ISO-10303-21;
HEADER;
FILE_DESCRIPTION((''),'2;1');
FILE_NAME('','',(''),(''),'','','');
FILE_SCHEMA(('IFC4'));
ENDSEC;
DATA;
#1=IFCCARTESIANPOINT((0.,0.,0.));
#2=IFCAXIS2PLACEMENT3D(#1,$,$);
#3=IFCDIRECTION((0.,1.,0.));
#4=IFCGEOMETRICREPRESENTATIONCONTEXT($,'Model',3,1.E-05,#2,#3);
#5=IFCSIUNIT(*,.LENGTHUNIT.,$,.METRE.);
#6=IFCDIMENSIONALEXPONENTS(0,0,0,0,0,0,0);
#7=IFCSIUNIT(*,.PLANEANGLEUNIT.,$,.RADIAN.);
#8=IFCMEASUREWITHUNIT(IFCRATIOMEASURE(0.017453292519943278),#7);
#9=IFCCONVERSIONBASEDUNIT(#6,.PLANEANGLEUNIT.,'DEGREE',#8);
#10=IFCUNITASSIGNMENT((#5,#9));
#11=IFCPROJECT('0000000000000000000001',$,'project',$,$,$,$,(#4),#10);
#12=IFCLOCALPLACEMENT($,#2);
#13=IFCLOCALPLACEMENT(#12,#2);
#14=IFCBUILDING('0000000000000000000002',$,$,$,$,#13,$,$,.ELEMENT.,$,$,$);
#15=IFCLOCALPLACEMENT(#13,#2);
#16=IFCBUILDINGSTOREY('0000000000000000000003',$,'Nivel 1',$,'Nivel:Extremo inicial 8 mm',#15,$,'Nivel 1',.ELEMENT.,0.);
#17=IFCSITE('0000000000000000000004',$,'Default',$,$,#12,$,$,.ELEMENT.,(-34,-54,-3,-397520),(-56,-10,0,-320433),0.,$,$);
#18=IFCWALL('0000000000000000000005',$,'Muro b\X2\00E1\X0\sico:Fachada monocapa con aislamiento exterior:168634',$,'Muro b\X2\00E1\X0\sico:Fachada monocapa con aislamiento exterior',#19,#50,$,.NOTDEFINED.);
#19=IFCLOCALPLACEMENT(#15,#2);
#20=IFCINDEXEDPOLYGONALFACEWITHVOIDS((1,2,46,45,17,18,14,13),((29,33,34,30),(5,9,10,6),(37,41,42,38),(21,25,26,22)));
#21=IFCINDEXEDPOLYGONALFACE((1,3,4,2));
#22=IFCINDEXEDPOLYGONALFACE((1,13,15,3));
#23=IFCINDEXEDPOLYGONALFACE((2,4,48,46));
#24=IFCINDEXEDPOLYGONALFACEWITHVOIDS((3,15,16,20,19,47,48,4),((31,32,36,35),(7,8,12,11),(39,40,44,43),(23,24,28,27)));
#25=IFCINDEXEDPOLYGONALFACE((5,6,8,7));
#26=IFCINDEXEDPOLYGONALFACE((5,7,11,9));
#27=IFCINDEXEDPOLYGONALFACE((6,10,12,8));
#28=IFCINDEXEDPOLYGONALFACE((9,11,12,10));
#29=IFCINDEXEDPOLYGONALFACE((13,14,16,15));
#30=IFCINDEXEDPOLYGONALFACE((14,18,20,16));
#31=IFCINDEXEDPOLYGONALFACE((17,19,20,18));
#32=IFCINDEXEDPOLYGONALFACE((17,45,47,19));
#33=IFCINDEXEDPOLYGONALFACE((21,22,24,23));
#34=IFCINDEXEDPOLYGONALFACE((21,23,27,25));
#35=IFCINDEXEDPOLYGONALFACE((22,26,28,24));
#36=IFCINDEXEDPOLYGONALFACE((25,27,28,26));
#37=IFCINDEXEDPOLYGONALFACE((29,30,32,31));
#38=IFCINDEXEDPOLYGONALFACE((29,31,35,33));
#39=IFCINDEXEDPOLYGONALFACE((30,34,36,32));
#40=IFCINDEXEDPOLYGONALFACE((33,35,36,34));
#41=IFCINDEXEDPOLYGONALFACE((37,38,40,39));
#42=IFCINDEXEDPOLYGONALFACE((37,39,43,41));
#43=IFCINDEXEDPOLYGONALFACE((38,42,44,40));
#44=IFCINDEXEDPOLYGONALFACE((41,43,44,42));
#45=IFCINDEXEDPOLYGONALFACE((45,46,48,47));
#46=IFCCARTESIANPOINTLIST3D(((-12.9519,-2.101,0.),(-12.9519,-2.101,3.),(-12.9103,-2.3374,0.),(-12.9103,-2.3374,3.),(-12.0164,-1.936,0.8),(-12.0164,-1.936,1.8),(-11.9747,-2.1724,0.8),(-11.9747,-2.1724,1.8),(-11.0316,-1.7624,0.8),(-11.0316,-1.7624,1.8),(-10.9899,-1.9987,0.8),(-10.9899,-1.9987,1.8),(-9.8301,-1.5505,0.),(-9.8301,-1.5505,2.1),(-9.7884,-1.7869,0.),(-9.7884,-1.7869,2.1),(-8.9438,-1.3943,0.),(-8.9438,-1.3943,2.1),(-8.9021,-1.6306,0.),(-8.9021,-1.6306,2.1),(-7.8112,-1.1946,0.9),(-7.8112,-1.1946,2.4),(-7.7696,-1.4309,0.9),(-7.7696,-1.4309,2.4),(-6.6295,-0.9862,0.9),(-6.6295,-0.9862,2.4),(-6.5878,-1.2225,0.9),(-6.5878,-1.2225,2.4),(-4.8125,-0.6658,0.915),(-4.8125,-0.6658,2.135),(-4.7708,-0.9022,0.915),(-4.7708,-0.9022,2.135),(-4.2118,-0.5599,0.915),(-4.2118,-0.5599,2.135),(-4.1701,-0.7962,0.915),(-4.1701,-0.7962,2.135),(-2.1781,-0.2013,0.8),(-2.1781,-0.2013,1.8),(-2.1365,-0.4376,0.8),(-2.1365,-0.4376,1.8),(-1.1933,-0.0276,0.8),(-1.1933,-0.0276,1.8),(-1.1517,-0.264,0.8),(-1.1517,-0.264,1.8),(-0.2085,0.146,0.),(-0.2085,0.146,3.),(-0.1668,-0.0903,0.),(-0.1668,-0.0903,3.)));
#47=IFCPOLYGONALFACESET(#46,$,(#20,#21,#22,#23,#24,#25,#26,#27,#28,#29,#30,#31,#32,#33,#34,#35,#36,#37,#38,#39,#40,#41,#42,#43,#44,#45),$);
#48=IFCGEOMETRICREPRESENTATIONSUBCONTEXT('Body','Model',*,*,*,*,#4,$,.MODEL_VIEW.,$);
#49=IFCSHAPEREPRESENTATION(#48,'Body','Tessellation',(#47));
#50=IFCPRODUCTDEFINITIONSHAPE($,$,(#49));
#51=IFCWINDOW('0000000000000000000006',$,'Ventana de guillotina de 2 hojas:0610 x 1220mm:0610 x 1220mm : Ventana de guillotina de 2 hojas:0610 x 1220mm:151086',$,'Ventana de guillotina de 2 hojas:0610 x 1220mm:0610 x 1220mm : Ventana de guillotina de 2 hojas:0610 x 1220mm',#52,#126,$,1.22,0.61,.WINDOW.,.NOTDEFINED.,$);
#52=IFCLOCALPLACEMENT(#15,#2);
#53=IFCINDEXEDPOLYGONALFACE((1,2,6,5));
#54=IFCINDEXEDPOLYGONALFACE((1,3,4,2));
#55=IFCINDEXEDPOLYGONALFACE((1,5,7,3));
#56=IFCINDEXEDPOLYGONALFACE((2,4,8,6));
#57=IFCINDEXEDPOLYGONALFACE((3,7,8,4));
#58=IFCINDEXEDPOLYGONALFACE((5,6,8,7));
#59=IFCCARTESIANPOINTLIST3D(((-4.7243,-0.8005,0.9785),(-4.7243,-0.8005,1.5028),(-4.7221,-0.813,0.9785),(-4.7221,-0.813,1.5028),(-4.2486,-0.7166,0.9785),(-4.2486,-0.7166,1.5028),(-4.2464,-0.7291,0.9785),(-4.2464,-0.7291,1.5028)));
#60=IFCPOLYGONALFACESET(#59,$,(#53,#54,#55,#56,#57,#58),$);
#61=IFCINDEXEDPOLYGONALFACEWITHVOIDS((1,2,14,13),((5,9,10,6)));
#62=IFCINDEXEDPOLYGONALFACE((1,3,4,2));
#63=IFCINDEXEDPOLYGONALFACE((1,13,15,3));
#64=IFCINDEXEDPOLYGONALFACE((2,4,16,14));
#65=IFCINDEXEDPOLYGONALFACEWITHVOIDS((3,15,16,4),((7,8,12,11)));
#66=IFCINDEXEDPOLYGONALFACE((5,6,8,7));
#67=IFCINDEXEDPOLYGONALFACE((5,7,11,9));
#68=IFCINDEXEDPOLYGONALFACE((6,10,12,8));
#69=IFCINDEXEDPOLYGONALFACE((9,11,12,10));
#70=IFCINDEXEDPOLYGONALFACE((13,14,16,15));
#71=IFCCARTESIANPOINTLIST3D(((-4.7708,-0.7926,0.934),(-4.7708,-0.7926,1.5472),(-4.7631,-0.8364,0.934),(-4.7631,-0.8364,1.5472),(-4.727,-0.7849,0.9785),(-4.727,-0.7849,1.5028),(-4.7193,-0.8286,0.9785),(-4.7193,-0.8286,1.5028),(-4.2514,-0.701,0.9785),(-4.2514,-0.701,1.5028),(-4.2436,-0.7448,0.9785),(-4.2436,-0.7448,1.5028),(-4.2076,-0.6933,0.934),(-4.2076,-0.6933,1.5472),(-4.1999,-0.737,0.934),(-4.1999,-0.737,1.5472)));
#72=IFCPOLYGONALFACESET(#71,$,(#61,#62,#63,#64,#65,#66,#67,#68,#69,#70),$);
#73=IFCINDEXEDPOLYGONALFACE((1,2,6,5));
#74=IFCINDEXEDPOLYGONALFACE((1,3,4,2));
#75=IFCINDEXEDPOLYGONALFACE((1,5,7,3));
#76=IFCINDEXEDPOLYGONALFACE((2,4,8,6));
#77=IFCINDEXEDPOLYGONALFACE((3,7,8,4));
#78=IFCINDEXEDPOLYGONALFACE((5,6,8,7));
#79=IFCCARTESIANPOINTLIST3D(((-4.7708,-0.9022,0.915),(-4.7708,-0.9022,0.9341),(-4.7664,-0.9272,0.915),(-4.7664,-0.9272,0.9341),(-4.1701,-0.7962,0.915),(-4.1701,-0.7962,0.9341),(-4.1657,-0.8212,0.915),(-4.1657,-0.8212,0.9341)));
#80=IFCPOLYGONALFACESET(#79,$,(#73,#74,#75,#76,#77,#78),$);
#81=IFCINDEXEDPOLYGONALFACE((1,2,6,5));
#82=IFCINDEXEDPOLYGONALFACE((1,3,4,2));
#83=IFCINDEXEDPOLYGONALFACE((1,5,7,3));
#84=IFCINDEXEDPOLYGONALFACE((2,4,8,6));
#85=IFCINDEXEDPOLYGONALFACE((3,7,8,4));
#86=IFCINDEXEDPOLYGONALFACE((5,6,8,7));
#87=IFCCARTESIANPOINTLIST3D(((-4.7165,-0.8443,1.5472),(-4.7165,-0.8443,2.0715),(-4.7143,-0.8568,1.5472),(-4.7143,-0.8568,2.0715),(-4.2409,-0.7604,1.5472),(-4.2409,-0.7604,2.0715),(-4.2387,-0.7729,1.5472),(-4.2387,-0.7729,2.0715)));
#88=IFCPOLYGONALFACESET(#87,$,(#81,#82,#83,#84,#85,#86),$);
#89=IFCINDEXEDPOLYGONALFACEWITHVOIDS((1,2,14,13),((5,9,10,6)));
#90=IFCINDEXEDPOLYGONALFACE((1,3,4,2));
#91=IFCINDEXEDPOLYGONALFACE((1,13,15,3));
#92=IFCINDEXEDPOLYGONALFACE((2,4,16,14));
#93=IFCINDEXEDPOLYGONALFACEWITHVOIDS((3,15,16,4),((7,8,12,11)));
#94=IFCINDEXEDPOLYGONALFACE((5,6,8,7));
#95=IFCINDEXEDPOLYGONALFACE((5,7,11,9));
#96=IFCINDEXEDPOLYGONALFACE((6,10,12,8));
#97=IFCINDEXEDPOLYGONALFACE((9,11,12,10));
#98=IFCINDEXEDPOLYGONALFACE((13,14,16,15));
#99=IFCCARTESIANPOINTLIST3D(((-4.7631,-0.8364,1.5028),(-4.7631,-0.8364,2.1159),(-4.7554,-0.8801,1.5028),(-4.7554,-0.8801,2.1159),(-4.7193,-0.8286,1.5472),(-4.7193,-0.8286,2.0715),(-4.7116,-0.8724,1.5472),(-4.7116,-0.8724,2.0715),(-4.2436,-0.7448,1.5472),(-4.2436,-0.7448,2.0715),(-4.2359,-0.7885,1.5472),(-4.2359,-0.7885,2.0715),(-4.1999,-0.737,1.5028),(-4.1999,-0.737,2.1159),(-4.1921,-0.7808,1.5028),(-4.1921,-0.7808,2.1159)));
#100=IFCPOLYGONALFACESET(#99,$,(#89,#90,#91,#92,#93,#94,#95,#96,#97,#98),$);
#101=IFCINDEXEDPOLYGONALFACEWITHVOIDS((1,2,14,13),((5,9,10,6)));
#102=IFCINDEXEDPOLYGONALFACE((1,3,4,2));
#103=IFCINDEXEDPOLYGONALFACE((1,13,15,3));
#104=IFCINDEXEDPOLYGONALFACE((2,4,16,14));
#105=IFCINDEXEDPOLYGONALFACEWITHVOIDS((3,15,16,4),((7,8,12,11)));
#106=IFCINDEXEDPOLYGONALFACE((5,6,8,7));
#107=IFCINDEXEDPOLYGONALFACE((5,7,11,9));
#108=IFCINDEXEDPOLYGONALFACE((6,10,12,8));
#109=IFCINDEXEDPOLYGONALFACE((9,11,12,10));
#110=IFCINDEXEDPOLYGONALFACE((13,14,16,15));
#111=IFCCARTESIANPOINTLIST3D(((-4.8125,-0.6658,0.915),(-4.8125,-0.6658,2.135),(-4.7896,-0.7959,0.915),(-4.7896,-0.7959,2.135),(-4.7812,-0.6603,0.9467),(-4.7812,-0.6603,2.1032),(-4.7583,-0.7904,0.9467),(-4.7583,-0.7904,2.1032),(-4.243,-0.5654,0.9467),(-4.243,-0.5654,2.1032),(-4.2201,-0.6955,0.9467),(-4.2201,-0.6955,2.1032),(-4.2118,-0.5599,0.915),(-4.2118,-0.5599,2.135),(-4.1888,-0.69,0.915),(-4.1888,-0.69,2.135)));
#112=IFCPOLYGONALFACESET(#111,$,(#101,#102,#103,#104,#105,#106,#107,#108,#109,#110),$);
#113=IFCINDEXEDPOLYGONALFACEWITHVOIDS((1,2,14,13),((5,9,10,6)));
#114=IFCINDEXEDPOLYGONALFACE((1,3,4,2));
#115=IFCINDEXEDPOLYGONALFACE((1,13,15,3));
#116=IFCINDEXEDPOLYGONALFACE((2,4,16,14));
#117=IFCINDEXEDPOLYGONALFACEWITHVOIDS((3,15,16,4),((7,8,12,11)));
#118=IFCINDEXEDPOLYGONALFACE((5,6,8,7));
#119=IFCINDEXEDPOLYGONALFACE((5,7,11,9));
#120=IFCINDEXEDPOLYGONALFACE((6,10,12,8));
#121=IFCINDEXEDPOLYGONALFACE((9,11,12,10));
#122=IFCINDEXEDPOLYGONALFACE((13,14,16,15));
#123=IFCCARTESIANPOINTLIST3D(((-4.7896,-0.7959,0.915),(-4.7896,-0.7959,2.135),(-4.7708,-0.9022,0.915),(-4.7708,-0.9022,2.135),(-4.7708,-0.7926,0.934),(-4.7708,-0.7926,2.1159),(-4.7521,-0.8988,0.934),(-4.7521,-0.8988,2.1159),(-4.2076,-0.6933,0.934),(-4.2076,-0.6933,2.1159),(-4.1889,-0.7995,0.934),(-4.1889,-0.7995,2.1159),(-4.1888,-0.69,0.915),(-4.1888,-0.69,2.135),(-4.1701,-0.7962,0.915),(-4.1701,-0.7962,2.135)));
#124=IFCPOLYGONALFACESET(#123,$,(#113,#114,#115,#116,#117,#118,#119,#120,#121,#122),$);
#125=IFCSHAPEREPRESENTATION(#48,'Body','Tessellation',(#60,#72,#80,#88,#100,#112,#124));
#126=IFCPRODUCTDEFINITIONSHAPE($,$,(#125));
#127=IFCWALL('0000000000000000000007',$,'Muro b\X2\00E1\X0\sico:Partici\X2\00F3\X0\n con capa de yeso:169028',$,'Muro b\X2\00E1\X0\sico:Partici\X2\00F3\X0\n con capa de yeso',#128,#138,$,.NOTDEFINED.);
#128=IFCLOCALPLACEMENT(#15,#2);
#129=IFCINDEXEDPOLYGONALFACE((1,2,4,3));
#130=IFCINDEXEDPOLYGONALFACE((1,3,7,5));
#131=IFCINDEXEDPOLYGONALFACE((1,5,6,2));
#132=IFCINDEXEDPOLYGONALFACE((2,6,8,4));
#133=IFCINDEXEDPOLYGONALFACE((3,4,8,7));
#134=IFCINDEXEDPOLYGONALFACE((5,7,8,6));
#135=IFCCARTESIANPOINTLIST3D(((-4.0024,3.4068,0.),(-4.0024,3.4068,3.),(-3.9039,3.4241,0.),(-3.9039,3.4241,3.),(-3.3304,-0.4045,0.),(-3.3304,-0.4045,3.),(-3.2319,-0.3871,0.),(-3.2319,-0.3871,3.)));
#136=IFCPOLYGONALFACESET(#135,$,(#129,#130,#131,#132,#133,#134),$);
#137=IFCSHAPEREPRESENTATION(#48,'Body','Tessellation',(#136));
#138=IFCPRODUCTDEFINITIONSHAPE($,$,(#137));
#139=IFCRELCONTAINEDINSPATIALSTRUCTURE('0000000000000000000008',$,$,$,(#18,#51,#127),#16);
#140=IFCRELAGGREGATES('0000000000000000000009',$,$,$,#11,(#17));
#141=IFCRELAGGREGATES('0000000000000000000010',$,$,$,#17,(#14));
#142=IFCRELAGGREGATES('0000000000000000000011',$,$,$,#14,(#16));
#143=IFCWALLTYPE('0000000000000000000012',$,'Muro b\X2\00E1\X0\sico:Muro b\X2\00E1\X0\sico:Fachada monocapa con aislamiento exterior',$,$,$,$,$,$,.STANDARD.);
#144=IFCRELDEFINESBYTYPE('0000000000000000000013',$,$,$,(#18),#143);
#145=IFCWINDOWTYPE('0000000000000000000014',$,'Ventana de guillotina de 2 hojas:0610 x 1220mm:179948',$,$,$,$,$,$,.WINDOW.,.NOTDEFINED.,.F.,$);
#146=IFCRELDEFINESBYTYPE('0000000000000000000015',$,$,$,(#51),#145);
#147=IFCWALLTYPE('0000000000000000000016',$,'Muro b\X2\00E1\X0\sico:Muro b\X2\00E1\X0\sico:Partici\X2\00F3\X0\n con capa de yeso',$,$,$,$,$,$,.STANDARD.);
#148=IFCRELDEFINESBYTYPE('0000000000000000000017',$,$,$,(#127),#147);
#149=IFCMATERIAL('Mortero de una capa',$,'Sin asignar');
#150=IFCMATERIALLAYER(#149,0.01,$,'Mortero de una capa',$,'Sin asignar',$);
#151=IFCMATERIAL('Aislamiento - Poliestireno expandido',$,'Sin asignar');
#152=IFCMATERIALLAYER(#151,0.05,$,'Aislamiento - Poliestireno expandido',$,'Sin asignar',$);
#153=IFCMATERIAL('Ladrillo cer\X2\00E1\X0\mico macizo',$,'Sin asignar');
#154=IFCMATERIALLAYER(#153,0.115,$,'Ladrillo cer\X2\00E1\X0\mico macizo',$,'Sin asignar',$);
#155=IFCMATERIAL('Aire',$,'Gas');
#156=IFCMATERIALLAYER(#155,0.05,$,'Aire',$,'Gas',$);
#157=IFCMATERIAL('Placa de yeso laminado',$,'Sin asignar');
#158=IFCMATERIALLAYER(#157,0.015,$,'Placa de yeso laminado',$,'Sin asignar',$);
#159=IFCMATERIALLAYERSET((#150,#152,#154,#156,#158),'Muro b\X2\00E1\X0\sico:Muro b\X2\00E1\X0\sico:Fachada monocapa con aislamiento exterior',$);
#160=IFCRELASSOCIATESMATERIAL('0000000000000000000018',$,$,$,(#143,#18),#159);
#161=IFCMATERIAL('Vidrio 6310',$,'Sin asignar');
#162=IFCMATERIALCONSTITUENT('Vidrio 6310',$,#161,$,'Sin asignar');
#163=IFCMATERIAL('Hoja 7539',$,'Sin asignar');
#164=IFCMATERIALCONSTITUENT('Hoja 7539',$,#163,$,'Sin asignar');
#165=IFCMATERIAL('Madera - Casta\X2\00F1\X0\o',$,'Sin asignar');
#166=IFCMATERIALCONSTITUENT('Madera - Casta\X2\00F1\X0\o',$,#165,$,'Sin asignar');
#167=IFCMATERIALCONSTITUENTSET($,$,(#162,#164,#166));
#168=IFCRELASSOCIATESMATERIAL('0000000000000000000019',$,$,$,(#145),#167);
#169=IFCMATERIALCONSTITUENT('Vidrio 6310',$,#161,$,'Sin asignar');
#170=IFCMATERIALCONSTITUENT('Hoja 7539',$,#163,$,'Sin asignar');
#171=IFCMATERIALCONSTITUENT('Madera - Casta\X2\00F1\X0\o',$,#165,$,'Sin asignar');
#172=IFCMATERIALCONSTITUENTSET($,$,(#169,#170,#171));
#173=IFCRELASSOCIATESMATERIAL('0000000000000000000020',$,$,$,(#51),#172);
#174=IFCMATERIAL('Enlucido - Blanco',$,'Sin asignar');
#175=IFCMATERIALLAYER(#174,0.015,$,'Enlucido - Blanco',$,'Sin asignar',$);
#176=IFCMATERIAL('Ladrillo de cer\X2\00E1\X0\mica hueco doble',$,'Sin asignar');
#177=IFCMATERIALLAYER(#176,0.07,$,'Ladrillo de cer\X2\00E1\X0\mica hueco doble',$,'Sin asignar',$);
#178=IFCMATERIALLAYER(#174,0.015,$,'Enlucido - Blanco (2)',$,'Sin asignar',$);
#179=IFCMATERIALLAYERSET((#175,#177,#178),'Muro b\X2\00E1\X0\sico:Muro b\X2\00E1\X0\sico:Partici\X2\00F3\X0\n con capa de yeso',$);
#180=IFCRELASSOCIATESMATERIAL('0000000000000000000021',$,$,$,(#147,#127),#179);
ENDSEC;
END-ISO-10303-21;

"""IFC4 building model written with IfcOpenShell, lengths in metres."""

from ifc_helpers import new_model, entity, si_unit, converted_unit, direction, frame, frame_2d, origin, origin_2d_with_axis, place, context, subcontext, project, spatial, polyline, rectangle, outline, extrude, source, transform, mapped, material, layer, layer_set, layer_usage, constituent, constituent_set, type_object, type_shapes, element, fill, save


model = new_model("IFC4")

# Units and contexts
model_context = context("Model", 3, precision=1e-05, world=origin(), true_north=direction((0.0, 1.0, 0.0)))
body_context = subcontext(model_context, "Body", "Model", "MODEL_VIEW")
ifc_project = project(units=[si_unit("LENGTHUNIT", "METRE"), converted_unit("PLANEANGLEUNIT", "DEGREE", entity("IfcRatioMeasure", 0.017453292519943278), si_unit("PLANEANGLEUNIT", "RADIAN"), dimensions=[0, 0, 0, 0, 0, 0, 0])], contexts=[model_context])

# Site, building, storey
site_placement = place(None, origin())
site = spatial("IfcSite", under=ifc_project, at=site_placement, Name="Default", CompositionType="ELEMENT", RefLatitude=(-34, -54, -3, -397520), RefLongitude=(-56, -10, 0, -320433), RefElevation=0.0)
building_placement = place(site_placement, origin())
building = spatial("IfcBuilding", under=site, at=building_placement, CompositionType="ELEMENT")
storey_placement = place(building_placement, origin())
storey = spatial("IfcBuildingStorey", under=building, at=storey_placement, Name="Nivel 1", ObjectType="Nivel:Extremo inicial 8 mm", LongName="Nivel 1", CompositionType="ELEMENT", Elevation=0.0)

# Shared definitions
ifc_material_1 = material(Name="Mortero de una capa", Category="Sin asignar")
ifc_layer_1 = layer(ifc_material_1, 0.01, Name="Mortero de una capa", Category="Sin asignar")
ifc_material_2 = material(Name="Aislamiento - Poliestireno expandido", Category="Sin asignar")
ifc_layer_2 = layer(ifc_material_2, 0.05, Name="Aislamiento - Poliestireno expandido", Category="Sin asignar")
ifc_material_3 = material(Name="Ladrillo cerámico macizo", Category="Sin asignar")
ifc_layer_3 = layer(ifc_material_3, 0.115, Name="Ladrillo cerámico macizo", Category="Sin asignar")
ifc_material_4 = material(Name="Aire", Category="Gas")
ifc_layer_4 = layer(ifc_material_4, 0.05, Name="Aire", Category="Gas")
ifc_material_5 = material(Name="Placa de yeso laminado", Category="Sin asignar")
ifc_layer_5 = layer(ifc_material_5, 0.015, Name="Placa de yeso laminado", Category="Sin asignar")
ifc_layer_set_1 = layer_set([ifc_layer_1, ifc_layer_2, ifc_layer_3, ifc_layer_4, ifc_layer_5], Name="Muro básico:Muro básico:Fachada monocapa con aislamiento exterior")
ifc_layer_usage_1 = layer_usage(ifc_layer_set_1, "AXIS2", "NEGATIVE", 0.12)
wall_type_1 = type_object("IfcWallType", Name="Muro básico:Muro básico:Fachada monocapa con aislamiento exterior", PredefinedType="STANDARD", material=ifc_layer_set_1)

# Wall, openings, window
wall_1_placement = place(storey_placement, frame((-0.1877, 0.0278, 0.0), z_axis=(0.0, 0.0, 1.0), x_axis=(-0.984808, -0.173648, 0.0)))
wall_1 = element("IfcWall", 1, at=wall_1_placement, inside=storey, type_object=wall_type_1, material=ifc_layer_usage_1, Name="Muro básico:Fachada monocapa con aislamiento exterior:168634", ObjectType="Muro básico:Fachada monocapa con aislamiento exterior", PredefinedType="NOTDEFINED", context=body_context, shape_type="SweptSolid", body=[
    extrude(rectangle(XDim=12.94, YDim=0.24, at=frame_2d((6.47, 0.0), x_axis=(-1.0, 0.0))), origin(), (0.0, 0.0, 1.0), 3.0),
])
opening_1_placement = place(wall_1_placement, frame((9.8119, 0.115, 0.0), z_axis=(0.0, 0.0, 1.0), x_axis=(-0.984808, 0.173648, 0.0)))
element("IfcOpeningElement", 2, at=opening_1_placement, cuts=wall_1, PredefinedType="OPENING", context=body_context, shape_type="SweptSolid", body=[
    extrude(rectangle(XDim=2.1, YDim=0.9, at=origin_2d_with_axis()), frame((0.4432, 0.3192, 1.05), z_axis=(0.173648, -0.984808, 0.0), x_axis=(0.0, 0.0, -1.0)), (0.0, 0.0, 1.0), 0.2448),
])
opening_2_placement = place(wall_1_placement, frame((12.0319, 0.115, 0.8), z_axis=(0.0, 0.0, 1.0), x_axis=(-0.984808, 0.173648, 0.0)))
element("IfcOpeningElement", 3, at=opening_2_placement, cuts=wall_1, PredefinedType="OPENING", context=body_context, shape_type="SweptSolid", body=[
    extrude(rectangle(XDim=1.0, YDim=1.0, at=frame_2d((0.0, 0.0), x_axis=(0.0, 1.0))), frame((0.4924, 0.3279, 0.5), z_axis=(0.173648, -0.984808, 0.0), x_axis=(-0.984808, -0.173648, 0.0)), (0.0, 0.0, 1.0), 0.2448),
])
opening_3_placement = place(wall_1_placement, frame((2.0419, 0.115, 0.8), z_axis=(0.0, 0.0, 1.0), x_axis=(-0.984808, 0.173648, 0.0)))
element("IfcOpeningElement", 4, at=opening_3_placement, cuts=wall_1, PredefinedType="OPENING", context=body_context, shape_type="SweptSolid", body=[
    extrude(rectangle(XDim=1.0, YDim=1.0, at=frame_2d((0.0, 0.0), x_axis=(0.0, 1.0))), frame((0.4924, 0.3279, 0.5), z_axis=(0.173648, -0.984808, 0.0), x_axis=(-0.984808, -0.173648, 0.0)), (0.0, 0.0, 1.0), 0.2448),
])
opening_4_placement = place(wall_1_placement, frame((4.7169, 0.115, 0.915), z_axis=(0.0, 0.0, 1.0), x_axis=(-0.984808, 0.173648, 0.0)))
opening_4 = element("IfcOpeningElement", 5, at=opening_4_placement, cuts=wall_1, PredefinedType="OPENING", context=body_context, shape_type="SweptSolid", body=[
    extrude(rectangle(XDim=1.22, YDim=0.61, at=frame_2d((0.0, 0.0), x_axis=(0.0, 1.0))), frame((0.3004, 0.294, 0.61), z_axis=(0.173648, -0.984808, 0.0), x_axis=(0.984808, 0.173648, 0.0)), (0.0, 0.0, 1.0), 0.2448),
])
opening_5_placement = place(wall_1_placement, frame((7.7619, 0.115, 0.9), z_axis=(0.0, 0.0, 1.0), x_axis=(-0.984808, 0.173648, 0.0)))
element("IfcOpeningElement", 6, at=opening_5_placement, cuts=wall_1, PredefinedType="OPENING", context=body_context, shape_type="SweptSolid", body=[
    extrude(rectangle(XDim=1.5, YDim=1.2, at=frame_2d((0.0, 0.0), x_axis=(0.0, 1.0))), frame((0.5909, 0.3453, 0.75), z_axis=(0.173648, -0.984808, 0.0), x_axis=(-0.984808, -0.173648, 0.0)), (0.0, 0.0, 1.0), 0.2448),
])
ifc_material_6 = material(Name="Vidrio 6310", Category="Sin asignar")
ifc_constituent_1 = constituent(ifc_material_6, Name="Vidrio 6310", Category="Sin asignar")
ifc_material_7 = material(Name="Hoja 7539", Category="Sin asignar")
ifc_constituent_2 = constituent(ifc_material_7, Name="Hoja 7539", Category="Sin asignar")
ifc_material_8 = material(Name="Madera - Castaño", Category="Sin asignar")
ifc_constituent_3 = constituent(ifc_material_8, Name="Madera - Castaño", Category="Sin asignar")
ifc_constituent_set_1 = constituent_set(constituents=[ifc_constituent_1, ifc_constituent_2, ifc_constituent_3])
ifc_constituent_4 = constituent(ifc_material_6, Name="Vidrio 6310", Category="Sin asignar")
ifc_constituent_5 = constituent(ifc_material_7, Name="Hoja 7539", Category="Sin asignar")
ifc_constituent_6 = constituent(ifc_material_8, Name="Madera - Castaño", Category="Sin asignar")
ifc_constituent_set_2 = constituent_set(constituents=[ifc_constituent_4, ifc_constituent_5, ifc_constituent_6])
window_type = type_object("IfcWindowType", Name="Ventana de guillotina de 2 hojas:0610 x 1220mm:179948", ParameterTakesPrecedence=False, PartitioningType="NOTDEFINED", PredefinedType="WINDOW", material=ifc_constituent_set_2)
shared_shape = source(origin(), body_context, "Body", "SweptSolid", [
    extrude(rectangle(XDim=0.483, YDim=0.0127, at=origin_2d_with_axis()), frame((0.305, -0.0881, 0.0635)), (0.0, 0.0, 1.0), 0.5243),
    extrude(outline(polyline([(-0.3066, -0.286), (0.3066, -0.286), (0.3066, 0.286), (-0.3066, 0.286), (-0.3066, -0.286)]), holes=[polyline([(0.2621, 0.2415), (0.2621, -0.2415), (-0.2621, -0.2415), (-0.2621, 0.2415), (0.2621, 0.2415)])]), frame((0.305, -0.1103, 0.3256), z_axis=(0.0, 1.0, 0.0), x_axis=(0.0, 0.0, -1.0)), (0.0, 0.0, 1.0), 0.0445),
    extrude(rectangle(XDim=0.61, YDim=0.0254, at=origin_2d_with_axis()), frame((0.305, 0.0103, 0.0)), (0.0, 0.0, 1.0), 0.0191),
    extrude(rectangle(XDim=0.483, YDim=0.0127, at=origin_2d_with_axis()), frame((0.305, -0.0436, 0.6322), z_axis=(0.0, 0.0, 1.0), x_axis=(-1.0, 0.0, 0.0)), (0.0, 0.0, 1.0), 0.5243),
    extrude(outline(polyline([(-0.3066, -0.2859), (0.3066, -0.2859), (0.3066, 0.2859), (-0.3066, 0.2859), (-0.3066, -0.2859)]), holes=[polyline([(0.2621, 0.2415), (0.2621, -0.2415), (-0.2621, -0.2415), (-0.2621, 0.2415), (0.2621, 0.2415)])]), frame((0.305, -0.0659, 0.8944), z_axis=(0.0, 1.0, 0.0), x_axis=(0.0, 0.0, -1.0)), (0.0, 0.0, 1.0), 0.0444),
    extrude(outline(polyline([(-0.61, -0.305), (0.61, -0.305), (0.61, 0.305), (-0.61, 0.305), (-0.61, -0.305)]), holes=[polyline([(0.5783, 0.2732), (0.5783, -0.2732), (-0.5782, -0.2732), (-0.5782, 0.2732), (0.5783, 0.2732)])]), frame((0.305, -0.2424, 0.61), z_axis=(0.0, 1.0, 0.0), x_axis=(0.0, 0.0, -1.0)), (0.0, 0.0, 1.0), 0.1321),
    extrude(outline(polyline([(-0.305, -0.61), (0.305, -0.61), (0.305, 0.61), (-0.305, 0.61), (-0.305, -0.61)]), holes=[polyline([(0.286, 0.591), (0.286, -0.5909), (-0.2859, -0.5909), (-0.2859, 0.591), (0.286, 0.591)])]), frame((0.305, -0.1103, 0.61), z_axis=(0.0, 1.0, 0.0), x_axis=(-1.0, 0.0, 0.0)), (0.0, 0.0, 1.0), 0.1079),
])
type_shapes(window_type, [shared_shape])
window_placement = place(opening_4_placement, frame((0.6432, 0.1059, 0.0), z_axis=(0.0, 0.0, 1.0), x_axis=(-0.984808, -0.173648, 0.0)))
window = element("IfcWindow", 7, at=window_placement, inside=storey, type_object=window_type, material=ifc_constituent_set_1, Name="Ventana de guillotina de 2 hojas:0610 x 1220mm:0610 x 1220mm : Ventana de guillotina de 2 hojas:0610 x 1220mm:151086", ObjectType="Ventana de guillotina de 2 hojas:0610 x 1220mm:0610 x 1220mm : Ventana de guillotina de 2 hojas:0610 x 1220mm", OverallHeight=1.22, OverallWidth=0.61, PartitioningType="NOTDEFINED", PredefinedType="WINDOW", context=body_context, shape_type="MappedRepresentation", body=[
    mapped(shared_shape, transform((0.0, 0.0, 0.0), scale=1.0)),
])
fill(opening_4, window)

# Wall
ifc_material_9 = material(Name="Enlucido - Blanco", Category="Sin asignar")
ifc_layer_6 = layer(ifc_material_9, 0.015, Name="Enlucido - Blanco", Category="Sin asignar")
ifc_material_10 = material(Name="Ladrillo de cerámica hueco doble", Category="Sin asignar")
ifc_layer_7 = layer(ifc_material_10, 0.07, Name="Ladrillo de cerámica hueco doble", Category="Sin asignar")
ifc_layer_8 = layer(ifc_material_9, 0.015, Name="Enlucido - Blanco (2)", Category="Sin asignar")
ifc_layer_set_2 = layer_set([ifc_layer_6, ifc_layer_7, ifc_layer_8], Name="Muro básico:Muro básico:Partición con capa de yeso")
ifc_layer_usage_2 = layer_usage(ifc_layer_set_2, "AXIS2", "NEGATIVE", 0.05)
wall_type_2 = type_object("IfcWallType", Name="Muro básico:Muro básico:Partición con capa de yeso", PredefinedType="STANDARD", material=ifc_layer_set_2)
wall_2_placement = place(storey_placement, frame((-3.2811, -0.3958, 0.0), z_axis=(0.0, 0.0, 1.0), x_axis=(-0.173648, 0.984808, 0.0)))
element("IfcWall", 8, at=wall_2_placement, inside=storey, type_object=wall_type_2, material=ifc_layer_usage_2, Name="Muro básico:Partición con capa de yeso:169028", ObjectType="Muro básico:Partición con capa de yeso", PredefinedType="NOTDEFINED", context=body_context, shape_type="SweptSolid", body=[
    extrude(rectangle(XDim=3.87, YDim=0.1, at=frame_2d((1.935, 0.0), x_axis=(-1.0, 0.0))), origin(), (0.0, 0.0, 1.0), 3.0),
])

save(model, "model.ifc")
